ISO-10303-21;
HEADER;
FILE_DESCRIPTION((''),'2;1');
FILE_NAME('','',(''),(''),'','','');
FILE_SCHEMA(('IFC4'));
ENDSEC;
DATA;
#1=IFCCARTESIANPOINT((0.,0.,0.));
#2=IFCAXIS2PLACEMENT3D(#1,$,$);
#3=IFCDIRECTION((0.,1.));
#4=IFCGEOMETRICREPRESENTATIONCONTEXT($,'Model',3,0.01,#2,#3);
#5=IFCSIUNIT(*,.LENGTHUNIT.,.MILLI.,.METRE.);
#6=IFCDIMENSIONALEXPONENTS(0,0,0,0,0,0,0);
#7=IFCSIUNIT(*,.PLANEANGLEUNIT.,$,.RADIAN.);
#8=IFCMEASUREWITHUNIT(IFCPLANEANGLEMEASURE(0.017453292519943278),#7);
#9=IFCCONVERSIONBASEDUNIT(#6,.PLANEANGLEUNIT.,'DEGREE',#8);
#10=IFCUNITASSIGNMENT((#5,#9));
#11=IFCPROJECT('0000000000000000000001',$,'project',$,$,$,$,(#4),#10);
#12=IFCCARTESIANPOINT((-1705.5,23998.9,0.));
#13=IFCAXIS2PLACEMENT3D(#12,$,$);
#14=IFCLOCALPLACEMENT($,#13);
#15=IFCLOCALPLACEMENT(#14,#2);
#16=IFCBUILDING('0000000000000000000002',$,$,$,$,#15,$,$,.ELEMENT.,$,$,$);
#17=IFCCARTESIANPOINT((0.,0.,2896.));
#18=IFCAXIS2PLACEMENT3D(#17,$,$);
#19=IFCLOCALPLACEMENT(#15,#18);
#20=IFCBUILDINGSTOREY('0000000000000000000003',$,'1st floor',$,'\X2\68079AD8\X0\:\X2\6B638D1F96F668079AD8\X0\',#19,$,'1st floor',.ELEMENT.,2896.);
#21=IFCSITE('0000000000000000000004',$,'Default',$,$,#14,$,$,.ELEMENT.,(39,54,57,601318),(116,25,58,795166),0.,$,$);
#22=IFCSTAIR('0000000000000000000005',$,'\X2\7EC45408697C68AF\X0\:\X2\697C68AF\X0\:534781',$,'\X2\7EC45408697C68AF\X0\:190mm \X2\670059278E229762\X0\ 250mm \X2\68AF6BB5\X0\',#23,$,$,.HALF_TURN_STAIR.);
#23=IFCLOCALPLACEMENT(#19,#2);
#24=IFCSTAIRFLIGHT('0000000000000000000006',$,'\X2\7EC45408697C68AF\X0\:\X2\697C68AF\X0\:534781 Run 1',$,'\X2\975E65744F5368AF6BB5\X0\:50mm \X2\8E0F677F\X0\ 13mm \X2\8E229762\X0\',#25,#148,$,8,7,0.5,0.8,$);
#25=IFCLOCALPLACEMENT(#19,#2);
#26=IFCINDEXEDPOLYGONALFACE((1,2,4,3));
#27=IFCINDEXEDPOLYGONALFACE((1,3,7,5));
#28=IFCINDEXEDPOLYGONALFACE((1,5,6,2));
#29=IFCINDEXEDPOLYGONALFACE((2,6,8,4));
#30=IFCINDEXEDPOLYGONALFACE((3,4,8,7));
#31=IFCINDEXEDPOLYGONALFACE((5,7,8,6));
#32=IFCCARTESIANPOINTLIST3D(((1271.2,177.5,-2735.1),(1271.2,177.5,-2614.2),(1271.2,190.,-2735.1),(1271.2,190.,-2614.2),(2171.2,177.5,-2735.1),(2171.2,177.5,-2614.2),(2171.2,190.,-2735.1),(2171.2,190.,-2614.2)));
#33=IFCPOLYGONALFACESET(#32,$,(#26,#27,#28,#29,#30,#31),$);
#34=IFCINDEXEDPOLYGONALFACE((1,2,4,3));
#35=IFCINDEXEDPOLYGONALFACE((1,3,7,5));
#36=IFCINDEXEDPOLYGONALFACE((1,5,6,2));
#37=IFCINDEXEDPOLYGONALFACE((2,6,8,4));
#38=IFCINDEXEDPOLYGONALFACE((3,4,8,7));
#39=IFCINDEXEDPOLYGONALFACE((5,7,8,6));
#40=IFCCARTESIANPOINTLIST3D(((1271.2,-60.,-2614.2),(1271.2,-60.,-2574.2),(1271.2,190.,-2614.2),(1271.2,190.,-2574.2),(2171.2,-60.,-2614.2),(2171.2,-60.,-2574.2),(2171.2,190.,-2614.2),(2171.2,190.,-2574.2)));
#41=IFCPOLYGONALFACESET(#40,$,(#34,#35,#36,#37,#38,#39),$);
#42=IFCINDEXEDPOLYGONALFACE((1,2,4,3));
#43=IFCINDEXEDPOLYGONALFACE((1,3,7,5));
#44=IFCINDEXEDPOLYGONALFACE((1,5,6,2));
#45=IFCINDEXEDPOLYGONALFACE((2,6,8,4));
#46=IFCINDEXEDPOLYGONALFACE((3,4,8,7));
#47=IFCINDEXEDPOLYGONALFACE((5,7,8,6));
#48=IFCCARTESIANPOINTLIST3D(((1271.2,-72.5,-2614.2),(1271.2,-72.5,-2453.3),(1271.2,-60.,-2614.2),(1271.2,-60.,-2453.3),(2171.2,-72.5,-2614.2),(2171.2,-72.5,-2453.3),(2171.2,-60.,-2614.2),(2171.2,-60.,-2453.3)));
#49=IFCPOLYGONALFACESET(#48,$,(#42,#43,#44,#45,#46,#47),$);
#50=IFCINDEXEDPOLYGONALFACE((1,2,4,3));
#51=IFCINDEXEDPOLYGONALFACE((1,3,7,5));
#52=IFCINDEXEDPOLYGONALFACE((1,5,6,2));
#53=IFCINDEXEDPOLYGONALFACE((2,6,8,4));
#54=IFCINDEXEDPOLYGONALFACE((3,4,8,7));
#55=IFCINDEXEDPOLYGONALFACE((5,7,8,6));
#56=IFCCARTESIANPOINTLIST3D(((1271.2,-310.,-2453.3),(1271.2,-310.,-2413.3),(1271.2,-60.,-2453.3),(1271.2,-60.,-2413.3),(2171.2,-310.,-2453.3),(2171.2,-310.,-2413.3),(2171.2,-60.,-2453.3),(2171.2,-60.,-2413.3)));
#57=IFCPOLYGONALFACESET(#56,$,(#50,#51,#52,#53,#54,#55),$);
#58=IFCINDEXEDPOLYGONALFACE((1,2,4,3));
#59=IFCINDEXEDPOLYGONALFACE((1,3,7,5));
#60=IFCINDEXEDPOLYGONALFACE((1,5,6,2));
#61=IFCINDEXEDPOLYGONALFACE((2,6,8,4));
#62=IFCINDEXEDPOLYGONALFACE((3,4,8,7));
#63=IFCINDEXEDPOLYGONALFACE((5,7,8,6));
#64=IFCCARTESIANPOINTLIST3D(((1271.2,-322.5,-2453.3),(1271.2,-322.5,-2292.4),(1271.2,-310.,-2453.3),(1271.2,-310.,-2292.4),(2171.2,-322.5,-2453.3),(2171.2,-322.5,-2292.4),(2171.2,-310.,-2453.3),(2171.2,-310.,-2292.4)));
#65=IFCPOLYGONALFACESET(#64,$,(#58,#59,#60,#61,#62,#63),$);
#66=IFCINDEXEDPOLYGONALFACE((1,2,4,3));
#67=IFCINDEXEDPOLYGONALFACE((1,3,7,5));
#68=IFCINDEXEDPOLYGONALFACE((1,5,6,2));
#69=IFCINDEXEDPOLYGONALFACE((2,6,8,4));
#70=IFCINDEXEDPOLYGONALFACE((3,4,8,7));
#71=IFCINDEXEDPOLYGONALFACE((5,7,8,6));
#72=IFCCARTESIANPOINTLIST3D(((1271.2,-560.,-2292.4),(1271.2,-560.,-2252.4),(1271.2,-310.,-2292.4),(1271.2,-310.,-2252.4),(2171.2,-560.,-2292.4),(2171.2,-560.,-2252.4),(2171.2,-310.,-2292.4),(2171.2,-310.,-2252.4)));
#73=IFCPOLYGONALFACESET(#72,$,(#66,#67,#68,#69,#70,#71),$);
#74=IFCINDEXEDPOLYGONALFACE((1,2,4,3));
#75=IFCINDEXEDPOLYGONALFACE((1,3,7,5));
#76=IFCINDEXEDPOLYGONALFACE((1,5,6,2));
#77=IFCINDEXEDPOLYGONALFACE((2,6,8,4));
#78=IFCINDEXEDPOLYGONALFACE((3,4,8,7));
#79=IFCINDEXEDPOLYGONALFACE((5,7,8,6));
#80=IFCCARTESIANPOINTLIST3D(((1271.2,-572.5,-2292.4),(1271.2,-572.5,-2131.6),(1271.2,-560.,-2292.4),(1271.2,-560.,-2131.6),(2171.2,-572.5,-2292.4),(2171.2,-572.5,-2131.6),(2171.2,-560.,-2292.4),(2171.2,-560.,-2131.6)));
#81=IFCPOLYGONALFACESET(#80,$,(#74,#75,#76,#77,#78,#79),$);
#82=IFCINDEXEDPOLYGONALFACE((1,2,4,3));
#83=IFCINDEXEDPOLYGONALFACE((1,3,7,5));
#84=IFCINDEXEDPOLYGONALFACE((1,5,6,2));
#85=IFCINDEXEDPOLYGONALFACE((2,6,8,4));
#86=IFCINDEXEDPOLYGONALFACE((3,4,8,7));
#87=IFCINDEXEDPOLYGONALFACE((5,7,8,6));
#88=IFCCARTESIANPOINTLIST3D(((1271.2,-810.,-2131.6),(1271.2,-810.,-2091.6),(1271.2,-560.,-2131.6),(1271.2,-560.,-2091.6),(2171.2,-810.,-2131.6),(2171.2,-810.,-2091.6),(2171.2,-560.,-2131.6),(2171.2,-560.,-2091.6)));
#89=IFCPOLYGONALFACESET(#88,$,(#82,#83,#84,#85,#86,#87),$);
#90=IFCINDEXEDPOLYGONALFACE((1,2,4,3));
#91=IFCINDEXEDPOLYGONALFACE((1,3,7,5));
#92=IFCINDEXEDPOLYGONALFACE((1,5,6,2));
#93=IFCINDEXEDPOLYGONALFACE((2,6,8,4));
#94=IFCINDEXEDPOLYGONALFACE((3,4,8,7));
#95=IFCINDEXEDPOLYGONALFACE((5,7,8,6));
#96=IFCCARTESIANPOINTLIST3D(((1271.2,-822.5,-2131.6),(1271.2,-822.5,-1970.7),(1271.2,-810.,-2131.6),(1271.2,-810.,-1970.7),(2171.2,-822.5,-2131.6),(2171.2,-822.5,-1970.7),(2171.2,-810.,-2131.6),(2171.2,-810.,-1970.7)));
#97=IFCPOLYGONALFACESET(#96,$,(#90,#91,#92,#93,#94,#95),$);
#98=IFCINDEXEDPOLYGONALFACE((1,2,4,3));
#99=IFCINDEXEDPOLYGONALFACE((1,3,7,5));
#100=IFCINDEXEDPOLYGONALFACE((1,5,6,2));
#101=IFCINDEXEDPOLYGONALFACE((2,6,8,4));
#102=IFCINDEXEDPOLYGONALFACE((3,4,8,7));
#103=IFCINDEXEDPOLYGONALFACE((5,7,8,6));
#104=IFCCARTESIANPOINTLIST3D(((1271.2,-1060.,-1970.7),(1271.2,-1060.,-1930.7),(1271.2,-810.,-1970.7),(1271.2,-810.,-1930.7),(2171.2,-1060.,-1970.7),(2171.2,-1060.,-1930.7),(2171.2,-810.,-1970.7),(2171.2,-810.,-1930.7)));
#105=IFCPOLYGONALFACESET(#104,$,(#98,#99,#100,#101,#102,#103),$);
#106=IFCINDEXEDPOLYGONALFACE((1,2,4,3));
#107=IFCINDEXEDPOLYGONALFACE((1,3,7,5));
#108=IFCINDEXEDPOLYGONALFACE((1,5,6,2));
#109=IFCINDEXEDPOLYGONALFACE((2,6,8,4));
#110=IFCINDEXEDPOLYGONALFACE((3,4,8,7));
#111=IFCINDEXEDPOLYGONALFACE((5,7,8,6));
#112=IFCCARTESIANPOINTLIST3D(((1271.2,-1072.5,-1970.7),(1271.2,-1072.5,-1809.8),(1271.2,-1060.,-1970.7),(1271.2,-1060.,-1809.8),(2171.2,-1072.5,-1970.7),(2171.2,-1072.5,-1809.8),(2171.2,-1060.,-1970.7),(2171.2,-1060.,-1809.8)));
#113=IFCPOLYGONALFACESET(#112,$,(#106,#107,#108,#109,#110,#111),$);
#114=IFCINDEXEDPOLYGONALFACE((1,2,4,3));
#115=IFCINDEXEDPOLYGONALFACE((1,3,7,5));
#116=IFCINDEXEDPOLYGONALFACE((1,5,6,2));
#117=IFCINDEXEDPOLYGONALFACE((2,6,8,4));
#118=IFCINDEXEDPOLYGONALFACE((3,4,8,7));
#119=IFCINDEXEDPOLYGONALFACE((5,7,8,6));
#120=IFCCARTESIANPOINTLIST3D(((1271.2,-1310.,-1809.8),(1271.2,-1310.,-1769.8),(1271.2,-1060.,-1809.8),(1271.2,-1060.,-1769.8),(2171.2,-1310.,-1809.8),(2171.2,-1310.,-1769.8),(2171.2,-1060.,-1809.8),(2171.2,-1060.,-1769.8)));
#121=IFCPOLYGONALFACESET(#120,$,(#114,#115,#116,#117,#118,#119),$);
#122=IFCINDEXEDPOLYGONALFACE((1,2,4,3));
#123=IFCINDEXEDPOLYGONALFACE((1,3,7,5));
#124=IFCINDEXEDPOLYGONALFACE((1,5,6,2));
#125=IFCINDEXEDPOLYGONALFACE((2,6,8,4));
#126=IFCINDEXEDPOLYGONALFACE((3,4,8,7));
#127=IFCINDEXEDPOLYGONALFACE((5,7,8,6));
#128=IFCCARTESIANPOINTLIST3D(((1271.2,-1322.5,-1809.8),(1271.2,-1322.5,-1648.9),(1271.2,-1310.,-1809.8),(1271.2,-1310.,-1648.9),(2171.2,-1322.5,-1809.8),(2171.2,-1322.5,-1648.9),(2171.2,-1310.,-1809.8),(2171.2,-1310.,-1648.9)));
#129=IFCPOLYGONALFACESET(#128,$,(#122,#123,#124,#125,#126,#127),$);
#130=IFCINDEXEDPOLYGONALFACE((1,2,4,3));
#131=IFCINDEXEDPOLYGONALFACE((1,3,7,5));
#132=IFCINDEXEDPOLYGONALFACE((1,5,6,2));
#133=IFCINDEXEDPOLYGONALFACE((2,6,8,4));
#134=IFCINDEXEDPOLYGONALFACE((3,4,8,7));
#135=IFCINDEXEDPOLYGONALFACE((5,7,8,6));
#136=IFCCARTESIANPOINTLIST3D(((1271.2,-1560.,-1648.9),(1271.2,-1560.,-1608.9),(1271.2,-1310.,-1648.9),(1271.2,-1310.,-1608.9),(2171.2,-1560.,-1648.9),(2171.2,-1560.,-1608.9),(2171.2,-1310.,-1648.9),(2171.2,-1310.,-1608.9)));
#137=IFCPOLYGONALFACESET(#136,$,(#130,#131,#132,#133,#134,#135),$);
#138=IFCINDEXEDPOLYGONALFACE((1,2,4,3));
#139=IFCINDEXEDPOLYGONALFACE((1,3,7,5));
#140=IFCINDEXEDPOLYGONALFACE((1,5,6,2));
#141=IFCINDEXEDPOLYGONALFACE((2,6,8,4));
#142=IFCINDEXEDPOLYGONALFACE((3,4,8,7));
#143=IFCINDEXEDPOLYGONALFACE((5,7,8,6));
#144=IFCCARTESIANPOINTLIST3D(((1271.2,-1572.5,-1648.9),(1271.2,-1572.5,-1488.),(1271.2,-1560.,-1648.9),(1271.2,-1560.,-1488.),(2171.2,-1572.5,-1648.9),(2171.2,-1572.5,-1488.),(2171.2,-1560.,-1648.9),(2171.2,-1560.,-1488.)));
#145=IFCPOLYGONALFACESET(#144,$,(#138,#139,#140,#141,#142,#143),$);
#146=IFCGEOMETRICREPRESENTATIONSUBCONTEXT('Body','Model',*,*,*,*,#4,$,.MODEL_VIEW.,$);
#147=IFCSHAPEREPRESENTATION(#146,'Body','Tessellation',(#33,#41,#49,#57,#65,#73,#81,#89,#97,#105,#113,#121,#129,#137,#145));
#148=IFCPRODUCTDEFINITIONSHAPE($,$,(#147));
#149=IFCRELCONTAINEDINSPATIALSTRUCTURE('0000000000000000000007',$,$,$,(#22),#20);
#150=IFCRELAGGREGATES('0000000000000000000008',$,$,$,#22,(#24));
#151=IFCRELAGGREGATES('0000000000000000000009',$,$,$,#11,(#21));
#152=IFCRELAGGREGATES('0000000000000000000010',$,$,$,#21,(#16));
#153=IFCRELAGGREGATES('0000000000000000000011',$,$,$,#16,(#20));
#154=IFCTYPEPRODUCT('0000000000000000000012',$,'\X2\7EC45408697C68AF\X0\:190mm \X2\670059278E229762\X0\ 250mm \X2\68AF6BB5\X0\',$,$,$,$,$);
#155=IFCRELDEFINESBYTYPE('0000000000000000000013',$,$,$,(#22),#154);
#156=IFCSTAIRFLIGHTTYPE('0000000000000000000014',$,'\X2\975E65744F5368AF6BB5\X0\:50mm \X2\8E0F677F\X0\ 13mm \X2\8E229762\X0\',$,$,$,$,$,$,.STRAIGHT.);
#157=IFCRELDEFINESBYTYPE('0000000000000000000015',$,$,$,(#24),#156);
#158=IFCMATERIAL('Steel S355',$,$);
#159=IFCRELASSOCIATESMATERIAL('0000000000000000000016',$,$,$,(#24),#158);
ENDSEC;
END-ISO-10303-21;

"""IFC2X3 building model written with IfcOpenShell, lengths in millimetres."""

from ifc_helpers import new_model, entity, si_unit, converted_unit, direction, frame, frame_2d, origin, origin_2d_with_axis, place, context, subcontext, project, spatial, rectangle, extrude, material, type_object, element, aggregate, save


model = new_model("IFC2X3")

# Units and contexts
model_context = context("Model", 3, precision=0.01, world=origin(), true_north=direction((0.0, 1.0)))
body_context = subcontext(model_context, "Body", "Model", "MODEL_VIEW")
ifc_project = project(units=[si_unit("LENGTHUNIT", "METRE", prefix="MILLI"), converted_unit("PLANEANGLEUNIT", "DEGREE", entity("IfcPlaneAngleMeasure", 0.017453292519943278), si_unit("PLANEANGLEUNIT", "RADIAN"), dimensions=[0, 0, 0, 0, 0, 0, 0])], contexts=[model_context])

# Site, building, storey
site_placement = place(None, frame((-1705.5, 23998.9, 0.0)))
site = spatial("IfcSite", under=ifc_project, at=site_placement, Name="Default", CompositionType="ELEMENT", RefLatitude=(39, 54, 57, 601318), RefLongitude=(116, 25, 58, 795166), RefElevation=0.0)
building_placement = place(site_placement, origin())
building = spatial("IfcBuilding", under=site, at=building_placement, CompositionType="ELEMENT")
storey_placement = place(building_placement, frame((0.0, 0.0, 2896.0)))
storey = spatial("IfcBuildingStorey", under=building, at=storey_placement, Name="1st floor", ObjectType="标高:正负零标高", LongName="1st floor", CompositionType="ELEMENT", Elevation=2896.0)

# Shared definitions
ifc_material_1 = material(Name="Steel S355")

# Stair
type_product = type_object("IfcTypeProduct", Name="组合楼梯:190mm 最大踢面 250mm 梯段")
stair_placement = place(storey_placement, origin())
stair = element("IfcStair", 1, at=stair_placement, inside=storey, type_object=type_product, Name="组合楼梯:楼梯:534781", ObjectType="组合楼梯:190mm 最大踢面 250mm 梯段", ShapeType="HALF_TURN_STAIR")

# Stair flight
stair_flight_type = type_object("IfcStairFlightType", Name="非整体梯段:50mm 踏板 13mm 踢面", PredefinedType="STRAIGHT")
stair_flight_1_placement = place(stair_placement, origin())
stair_flight_1 = element("IfcStairFlight", 2, at=stair_flight_1_placement, type_object=stair_flight_type, material=ifc_material_1, Name="组合楼梯:楼梯:534781 Run 1", ObjectType="非整体梯段:50mm 踏板 13mm 踢面", NumberOfRiser=8, NumberOfTreads=7, RiserHeight=0.5, TreadLength=0.8, context=body_context, shape_type="SweptSolid", body=[
    extrude(rectangle(XDim=900.0, YDim=12.5, at=origin_2d_with_axis()), frame((1721.2, 183.7, -2735.1)), (0.0, 0.0, 1.0), 120.9),
    extrude(rectangle(XDim=250.0, YDim=900.0, at=origin_2d_with_axis()), frame((1721.2, 65.0, -2614.2), z_axis=(0.0, 0.0, 1.0), x_axis=(0.0, 1.0, 0.0)), (0.0, 0.0, 1.0), 40.0),
    extrude(rectangle(XDim=900.0, YDim=12.5, at=origin_2d_with_axis()), frame((1721.2, -66.3, -2614.2)), (0.0, 0.0, 1.0), 160.9),
    extrude(rectangle(XDim=250.0, YDim=900.0, at=frame_2d((0.0, 0.0), x_axis=(1.0, 0.0))), frame((1721.2, -185.0, -2453.3), z_axis=(0.0, 0.0, 1.0), x_axis=(0.0, 1.0, 0.0)), (0.0, 0.0, 1.0), 40.0),
    extrude(rectangle(XDim=900.0, YDim=12.5, at=origin_2d_with_axis()), frame((1721.2, -316.3, -2453.3)), (0.0, 0.0, 1.0), 160.9),
    extrude(rectangle(XDim=250.0, YDim=900.0, at=frame_2d((0.0, 0.0), x_axis=(1.0, 0.0))), frame((1721.2, -435.0, -2292.4), z_axis=(0.0, 0.0, 1.0), x_axis=(0.0, 1.0, 0.0)), (0.0, 0.0, 1.0), 40.0),
    extrude(rectangle(XDim=900.0, YDim=12.5, at=origin_2d_with_axis()), frame((1721.2, -566.3, -2292.4)), (0.0, 0.0, 1.0), 160.9),
    extrude(rectangle(XDim=250.0, YDim=900.0, at=frame_2d((0.0, 0.0), x_axis=(1.0, 0.0))), frame((1721.2, -685.0, -2131.6), z_axis=(0.0, 0.0, 1.0), x_axis=(0.0, 1.0, 0.0)), (0.0, 0.0, 1.0), 40.0),
    extrude(rectangle(XDim=900.0, YDim=12.5, at=frame_2d((0.0, 0.0), x_axis=(1.0, 0.0))), frame((1721.2, -816.3, -2131.6)), (0.0, 0.0, 1.0), 160.9),
    extrude(rectangle(XDim=250.0, YDim=900.0, at=frame_2d((0.0, 0.0), x_axis=(1.0, 0.0))), frame((1721.2, -935.0, -1970.7), z_axis=(0.0, 0.0, 1.0), x_axis=(0.0, 1.0, 0.0)), (0.0, 0.0, 1.0), 40.0),
    extrude(rectangle(XDim=900.0, YDim=12.5, at=frame_2d((0.0, 0.0), x_axis=(1.0, 0.0))), frame((1721.2, -1066.3, -1970.7)), (0.0, 0.0, 1.0), 160.9),
    extrude(rectangle(XDim=250.0, YDim=900.0, at=frame_2d((0.0, 0.0), x_axis=(1.0, 0.0))), frame((1721.2, -1185.0, -1809.8), z_axis=(0.0, 0.0, 1.0), x_axis=(0.0, 1.0, 0.0)), (0.0, 0.0, 1.0), 40.0),
    extrude(rectangle(XDim=900.0, YDim=12.5, at=frame_2d((0.0, 0.0), x_axis=(1.0, 0.0))), frame((1721.2, -1316.3, -1809.8)), (0.0, 0.0, 1.0), 160.9),
    extrude(rectangle(XDim=250.0, YDim=900.0, at=frame_2d((0.0, 0.0), x_axis=(1.0, 0.0))), frame((1721.2, -1435.0, -1648.9), z_axis=(0.0, 0.0, 1.0), x_axis=(0.0, 1.0, 0.0)), (0.0, 0.0, 1.0), 40.0),
    extrude(rectangle(XDim=900.0, YDim=12.5, at=frame_2d((0.0, 0.0), x_axis=(1.0, 0.0))), frame((1721.2, -1566.3, -1648.9)), (0.0, 0.0, 1.0), 160.9),
])
aggregate(stair, [stair_flight_1])

save(model, "model.ifc")
